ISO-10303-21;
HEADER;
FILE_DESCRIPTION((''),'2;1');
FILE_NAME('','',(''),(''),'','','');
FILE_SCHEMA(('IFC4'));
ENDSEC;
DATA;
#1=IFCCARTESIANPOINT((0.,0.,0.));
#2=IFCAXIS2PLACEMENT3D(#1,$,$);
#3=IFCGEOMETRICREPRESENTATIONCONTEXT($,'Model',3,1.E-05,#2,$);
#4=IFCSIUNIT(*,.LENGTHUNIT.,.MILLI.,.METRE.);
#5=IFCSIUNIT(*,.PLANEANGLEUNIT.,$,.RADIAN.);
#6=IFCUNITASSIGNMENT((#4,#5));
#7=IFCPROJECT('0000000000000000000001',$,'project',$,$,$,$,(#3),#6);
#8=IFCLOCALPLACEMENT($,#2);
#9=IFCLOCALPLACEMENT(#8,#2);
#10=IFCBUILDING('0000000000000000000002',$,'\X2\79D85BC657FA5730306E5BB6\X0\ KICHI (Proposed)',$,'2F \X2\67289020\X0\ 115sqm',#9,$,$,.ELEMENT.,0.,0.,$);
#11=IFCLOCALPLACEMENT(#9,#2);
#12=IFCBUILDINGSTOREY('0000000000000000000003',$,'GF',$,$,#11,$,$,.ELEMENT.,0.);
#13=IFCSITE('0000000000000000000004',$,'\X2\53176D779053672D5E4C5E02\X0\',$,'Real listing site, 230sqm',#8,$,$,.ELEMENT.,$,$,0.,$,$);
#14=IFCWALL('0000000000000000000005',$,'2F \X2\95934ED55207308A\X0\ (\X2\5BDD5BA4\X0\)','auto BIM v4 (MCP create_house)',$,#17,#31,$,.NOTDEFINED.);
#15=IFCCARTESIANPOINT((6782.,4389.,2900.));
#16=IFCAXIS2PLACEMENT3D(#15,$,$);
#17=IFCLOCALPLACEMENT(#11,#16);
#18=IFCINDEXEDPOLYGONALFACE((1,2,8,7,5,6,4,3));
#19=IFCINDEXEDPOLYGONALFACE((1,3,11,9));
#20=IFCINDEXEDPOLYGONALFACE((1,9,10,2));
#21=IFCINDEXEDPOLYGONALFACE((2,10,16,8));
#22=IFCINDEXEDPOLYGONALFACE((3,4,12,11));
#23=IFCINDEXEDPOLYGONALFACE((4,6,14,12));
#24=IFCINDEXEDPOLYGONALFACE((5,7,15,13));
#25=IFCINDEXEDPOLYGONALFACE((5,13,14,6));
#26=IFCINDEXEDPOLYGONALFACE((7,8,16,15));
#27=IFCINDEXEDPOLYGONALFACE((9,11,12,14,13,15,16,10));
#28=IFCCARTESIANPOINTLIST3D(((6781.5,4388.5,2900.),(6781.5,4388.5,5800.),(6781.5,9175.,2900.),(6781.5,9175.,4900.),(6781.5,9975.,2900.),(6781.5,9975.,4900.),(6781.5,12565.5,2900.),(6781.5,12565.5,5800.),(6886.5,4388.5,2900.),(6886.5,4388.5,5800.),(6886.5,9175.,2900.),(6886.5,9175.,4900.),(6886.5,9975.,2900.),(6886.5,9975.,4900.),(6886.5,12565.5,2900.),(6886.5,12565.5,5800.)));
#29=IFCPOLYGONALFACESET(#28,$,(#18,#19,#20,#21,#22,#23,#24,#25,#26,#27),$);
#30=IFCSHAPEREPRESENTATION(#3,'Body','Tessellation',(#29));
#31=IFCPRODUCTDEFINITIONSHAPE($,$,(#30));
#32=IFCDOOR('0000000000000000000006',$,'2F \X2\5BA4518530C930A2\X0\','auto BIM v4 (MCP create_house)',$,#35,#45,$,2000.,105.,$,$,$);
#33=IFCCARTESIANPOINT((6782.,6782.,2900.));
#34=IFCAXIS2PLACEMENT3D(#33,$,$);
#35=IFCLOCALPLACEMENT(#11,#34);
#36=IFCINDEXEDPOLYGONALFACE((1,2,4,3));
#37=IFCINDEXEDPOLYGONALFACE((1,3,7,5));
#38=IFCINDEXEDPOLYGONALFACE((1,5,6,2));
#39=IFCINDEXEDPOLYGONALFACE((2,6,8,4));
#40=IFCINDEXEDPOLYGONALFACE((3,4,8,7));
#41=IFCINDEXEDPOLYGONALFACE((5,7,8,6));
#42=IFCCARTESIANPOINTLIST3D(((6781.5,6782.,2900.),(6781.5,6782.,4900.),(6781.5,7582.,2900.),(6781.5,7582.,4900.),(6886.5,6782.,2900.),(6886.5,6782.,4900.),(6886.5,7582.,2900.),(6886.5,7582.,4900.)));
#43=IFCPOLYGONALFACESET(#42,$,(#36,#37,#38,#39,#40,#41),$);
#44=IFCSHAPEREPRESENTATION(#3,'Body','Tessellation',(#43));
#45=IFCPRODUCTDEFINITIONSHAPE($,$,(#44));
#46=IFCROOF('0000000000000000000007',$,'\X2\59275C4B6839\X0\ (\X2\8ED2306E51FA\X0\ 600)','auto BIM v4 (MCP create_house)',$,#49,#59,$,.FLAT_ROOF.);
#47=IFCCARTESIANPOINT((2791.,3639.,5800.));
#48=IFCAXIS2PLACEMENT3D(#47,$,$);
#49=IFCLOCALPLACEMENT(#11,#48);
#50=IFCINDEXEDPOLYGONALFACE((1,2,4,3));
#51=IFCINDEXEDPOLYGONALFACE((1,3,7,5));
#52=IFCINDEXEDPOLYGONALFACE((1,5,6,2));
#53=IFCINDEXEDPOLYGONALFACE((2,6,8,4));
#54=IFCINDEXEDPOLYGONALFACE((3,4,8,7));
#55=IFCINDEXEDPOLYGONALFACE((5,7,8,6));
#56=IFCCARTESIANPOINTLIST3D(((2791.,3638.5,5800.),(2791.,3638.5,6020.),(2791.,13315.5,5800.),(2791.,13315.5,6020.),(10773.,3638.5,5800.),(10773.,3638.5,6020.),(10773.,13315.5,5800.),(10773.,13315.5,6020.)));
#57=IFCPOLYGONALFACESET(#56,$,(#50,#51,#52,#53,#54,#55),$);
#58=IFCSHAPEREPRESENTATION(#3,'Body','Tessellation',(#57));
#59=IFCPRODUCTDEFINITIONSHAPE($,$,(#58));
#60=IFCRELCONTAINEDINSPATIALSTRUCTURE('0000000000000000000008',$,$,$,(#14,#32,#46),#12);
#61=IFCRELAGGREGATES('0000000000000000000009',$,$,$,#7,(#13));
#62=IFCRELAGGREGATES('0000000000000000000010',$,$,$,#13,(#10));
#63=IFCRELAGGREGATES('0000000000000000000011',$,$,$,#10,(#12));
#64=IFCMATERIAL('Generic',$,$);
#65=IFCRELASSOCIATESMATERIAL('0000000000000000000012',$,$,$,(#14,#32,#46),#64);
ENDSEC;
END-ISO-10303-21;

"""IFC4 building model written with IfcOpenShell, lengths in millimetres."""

from ifc_helpers import new_model, si_unit, frame, frame_2d, origin, place, context, project, spatial, rectangle, extrude, material, element, fill, save


model = new_model("IFC4")

# Units and contexts
model_context = context("Model", 3, precision=1e-05, world=origin())
ifc_project = project(units=[si_unit("LENGTHUNIT", "METRE", prefix="MILLI"), si_unit("PLANEANGLEUNIT", "RADIAN")], contexts=[model_context])

# Site, building, storey
site_placement = place(None, origin())
site = spatial("IfcSite", under=ifc_project, at=site_placement, Name="北海道札幌市", ObjectType="Real listing site, 230sqm", CompositionType="ELEMENT", RefElevation=0.0)
building_placement = place(site_placement, origin())
building = spatial("IfcBuilding", under=site, at=building_placement, Name="秘密基地の家 KICHI (Proposed)", ObjectType="2F 木造 115sqm", CompositionType="ELEMENT", ElevationOfRefHeight=0.0, ElevationOfTerrain=0.0)
storey_placement = place(building_placement, origin())
storey = spatial("IfcBuildingStorey", under=building, at=storey_placement, Name="GF", CompositionType="ELEMENT", Elevation=0.0)

# Shared definitions
ifc_material = material(Name="Generic")

# Wall, opening, door
wall_1_placement = place(storey_placement, frame((6782.0, 4389.0, 2900.0)))
wall_1 = element("IfcWall", 1, at=wall_1_placement, inside=storey, material=ifc_material, Name="2F 間仕切り (寝室)", Description="auto BIM v4 (MCP create_house)", PredefinedType="NOTDEFINED", context=model_context, shape_type="SweptSolid", body=[
    extrude(rectangle(XDim=105.0, YDim=8177.0, at=frame_2d((52.0, 4088.0))), frame((6782.0, 4389.0, 2900.0)), (0.0, 0.0, 1.0), 2900.0),
])
opening_1_placement = place(storey_placement, frame((6782.0, 6782.0, 2900.0)))
opening_1 = element("IfcOpeningElement", 2, at=opening_1_placement, cuts=wall_1, PredefinedType="NOTDEFINED", context=model_context, shape_type="SweptSolid", body=[
    extrude(rectangle(XDim=105.0, YDim=800.0, at=frame_2d((52.0, 400.0))), frame((6782.0, 6782.0, 2900.0)), (0.0, 0.0, 1.0), 2000.0),
])
door_1_placement = place(storey_placement, frame((6782.0, 6782.0, 2900.0)))
door_1 = element("IfcDoor", 3, at=door_1_placement, inside=storey, material=ifc_material, Name="2F 室内ドア", Description="auto BIM v4 (MCP create_house)", OverallHeight=2000.0, OverallWidth=105.0, context=model_context, shape_type="SweptSolid", body=[
    extrude(rectangle(XDim=105.0, YDim=800.0, at=frame_2d((52.0, 400.0))), frame((6782.0, 6782.0, 2900.0)), (0.0, 0.0, 1.0), 2000.0),
])
fill(opening_1, door_1)

# Roof
roof_placement = place(storey_placement, frame((2791.0, 3639.0, 5800.0)))
element("IfcRoof", 4, at=roof_placement, inside=storey, material=ifc_material, Name="大屋根 (軒の出 600)", Description="auto BIM v4 (MCP create_house)", PredefinedType="FLAT_ROOF", context=model_context, shape_type="SweptSolid", body=[
    extrude(rectangle(XDim=7982.0, YDim=9677.0, at=frame_2d((3991.0, 4838.0))), frame((2791.0, 3639.0, 5800.0)), (0.0, 0.0, 1.0), 220.0),
])

save(model, "model.ifc")
